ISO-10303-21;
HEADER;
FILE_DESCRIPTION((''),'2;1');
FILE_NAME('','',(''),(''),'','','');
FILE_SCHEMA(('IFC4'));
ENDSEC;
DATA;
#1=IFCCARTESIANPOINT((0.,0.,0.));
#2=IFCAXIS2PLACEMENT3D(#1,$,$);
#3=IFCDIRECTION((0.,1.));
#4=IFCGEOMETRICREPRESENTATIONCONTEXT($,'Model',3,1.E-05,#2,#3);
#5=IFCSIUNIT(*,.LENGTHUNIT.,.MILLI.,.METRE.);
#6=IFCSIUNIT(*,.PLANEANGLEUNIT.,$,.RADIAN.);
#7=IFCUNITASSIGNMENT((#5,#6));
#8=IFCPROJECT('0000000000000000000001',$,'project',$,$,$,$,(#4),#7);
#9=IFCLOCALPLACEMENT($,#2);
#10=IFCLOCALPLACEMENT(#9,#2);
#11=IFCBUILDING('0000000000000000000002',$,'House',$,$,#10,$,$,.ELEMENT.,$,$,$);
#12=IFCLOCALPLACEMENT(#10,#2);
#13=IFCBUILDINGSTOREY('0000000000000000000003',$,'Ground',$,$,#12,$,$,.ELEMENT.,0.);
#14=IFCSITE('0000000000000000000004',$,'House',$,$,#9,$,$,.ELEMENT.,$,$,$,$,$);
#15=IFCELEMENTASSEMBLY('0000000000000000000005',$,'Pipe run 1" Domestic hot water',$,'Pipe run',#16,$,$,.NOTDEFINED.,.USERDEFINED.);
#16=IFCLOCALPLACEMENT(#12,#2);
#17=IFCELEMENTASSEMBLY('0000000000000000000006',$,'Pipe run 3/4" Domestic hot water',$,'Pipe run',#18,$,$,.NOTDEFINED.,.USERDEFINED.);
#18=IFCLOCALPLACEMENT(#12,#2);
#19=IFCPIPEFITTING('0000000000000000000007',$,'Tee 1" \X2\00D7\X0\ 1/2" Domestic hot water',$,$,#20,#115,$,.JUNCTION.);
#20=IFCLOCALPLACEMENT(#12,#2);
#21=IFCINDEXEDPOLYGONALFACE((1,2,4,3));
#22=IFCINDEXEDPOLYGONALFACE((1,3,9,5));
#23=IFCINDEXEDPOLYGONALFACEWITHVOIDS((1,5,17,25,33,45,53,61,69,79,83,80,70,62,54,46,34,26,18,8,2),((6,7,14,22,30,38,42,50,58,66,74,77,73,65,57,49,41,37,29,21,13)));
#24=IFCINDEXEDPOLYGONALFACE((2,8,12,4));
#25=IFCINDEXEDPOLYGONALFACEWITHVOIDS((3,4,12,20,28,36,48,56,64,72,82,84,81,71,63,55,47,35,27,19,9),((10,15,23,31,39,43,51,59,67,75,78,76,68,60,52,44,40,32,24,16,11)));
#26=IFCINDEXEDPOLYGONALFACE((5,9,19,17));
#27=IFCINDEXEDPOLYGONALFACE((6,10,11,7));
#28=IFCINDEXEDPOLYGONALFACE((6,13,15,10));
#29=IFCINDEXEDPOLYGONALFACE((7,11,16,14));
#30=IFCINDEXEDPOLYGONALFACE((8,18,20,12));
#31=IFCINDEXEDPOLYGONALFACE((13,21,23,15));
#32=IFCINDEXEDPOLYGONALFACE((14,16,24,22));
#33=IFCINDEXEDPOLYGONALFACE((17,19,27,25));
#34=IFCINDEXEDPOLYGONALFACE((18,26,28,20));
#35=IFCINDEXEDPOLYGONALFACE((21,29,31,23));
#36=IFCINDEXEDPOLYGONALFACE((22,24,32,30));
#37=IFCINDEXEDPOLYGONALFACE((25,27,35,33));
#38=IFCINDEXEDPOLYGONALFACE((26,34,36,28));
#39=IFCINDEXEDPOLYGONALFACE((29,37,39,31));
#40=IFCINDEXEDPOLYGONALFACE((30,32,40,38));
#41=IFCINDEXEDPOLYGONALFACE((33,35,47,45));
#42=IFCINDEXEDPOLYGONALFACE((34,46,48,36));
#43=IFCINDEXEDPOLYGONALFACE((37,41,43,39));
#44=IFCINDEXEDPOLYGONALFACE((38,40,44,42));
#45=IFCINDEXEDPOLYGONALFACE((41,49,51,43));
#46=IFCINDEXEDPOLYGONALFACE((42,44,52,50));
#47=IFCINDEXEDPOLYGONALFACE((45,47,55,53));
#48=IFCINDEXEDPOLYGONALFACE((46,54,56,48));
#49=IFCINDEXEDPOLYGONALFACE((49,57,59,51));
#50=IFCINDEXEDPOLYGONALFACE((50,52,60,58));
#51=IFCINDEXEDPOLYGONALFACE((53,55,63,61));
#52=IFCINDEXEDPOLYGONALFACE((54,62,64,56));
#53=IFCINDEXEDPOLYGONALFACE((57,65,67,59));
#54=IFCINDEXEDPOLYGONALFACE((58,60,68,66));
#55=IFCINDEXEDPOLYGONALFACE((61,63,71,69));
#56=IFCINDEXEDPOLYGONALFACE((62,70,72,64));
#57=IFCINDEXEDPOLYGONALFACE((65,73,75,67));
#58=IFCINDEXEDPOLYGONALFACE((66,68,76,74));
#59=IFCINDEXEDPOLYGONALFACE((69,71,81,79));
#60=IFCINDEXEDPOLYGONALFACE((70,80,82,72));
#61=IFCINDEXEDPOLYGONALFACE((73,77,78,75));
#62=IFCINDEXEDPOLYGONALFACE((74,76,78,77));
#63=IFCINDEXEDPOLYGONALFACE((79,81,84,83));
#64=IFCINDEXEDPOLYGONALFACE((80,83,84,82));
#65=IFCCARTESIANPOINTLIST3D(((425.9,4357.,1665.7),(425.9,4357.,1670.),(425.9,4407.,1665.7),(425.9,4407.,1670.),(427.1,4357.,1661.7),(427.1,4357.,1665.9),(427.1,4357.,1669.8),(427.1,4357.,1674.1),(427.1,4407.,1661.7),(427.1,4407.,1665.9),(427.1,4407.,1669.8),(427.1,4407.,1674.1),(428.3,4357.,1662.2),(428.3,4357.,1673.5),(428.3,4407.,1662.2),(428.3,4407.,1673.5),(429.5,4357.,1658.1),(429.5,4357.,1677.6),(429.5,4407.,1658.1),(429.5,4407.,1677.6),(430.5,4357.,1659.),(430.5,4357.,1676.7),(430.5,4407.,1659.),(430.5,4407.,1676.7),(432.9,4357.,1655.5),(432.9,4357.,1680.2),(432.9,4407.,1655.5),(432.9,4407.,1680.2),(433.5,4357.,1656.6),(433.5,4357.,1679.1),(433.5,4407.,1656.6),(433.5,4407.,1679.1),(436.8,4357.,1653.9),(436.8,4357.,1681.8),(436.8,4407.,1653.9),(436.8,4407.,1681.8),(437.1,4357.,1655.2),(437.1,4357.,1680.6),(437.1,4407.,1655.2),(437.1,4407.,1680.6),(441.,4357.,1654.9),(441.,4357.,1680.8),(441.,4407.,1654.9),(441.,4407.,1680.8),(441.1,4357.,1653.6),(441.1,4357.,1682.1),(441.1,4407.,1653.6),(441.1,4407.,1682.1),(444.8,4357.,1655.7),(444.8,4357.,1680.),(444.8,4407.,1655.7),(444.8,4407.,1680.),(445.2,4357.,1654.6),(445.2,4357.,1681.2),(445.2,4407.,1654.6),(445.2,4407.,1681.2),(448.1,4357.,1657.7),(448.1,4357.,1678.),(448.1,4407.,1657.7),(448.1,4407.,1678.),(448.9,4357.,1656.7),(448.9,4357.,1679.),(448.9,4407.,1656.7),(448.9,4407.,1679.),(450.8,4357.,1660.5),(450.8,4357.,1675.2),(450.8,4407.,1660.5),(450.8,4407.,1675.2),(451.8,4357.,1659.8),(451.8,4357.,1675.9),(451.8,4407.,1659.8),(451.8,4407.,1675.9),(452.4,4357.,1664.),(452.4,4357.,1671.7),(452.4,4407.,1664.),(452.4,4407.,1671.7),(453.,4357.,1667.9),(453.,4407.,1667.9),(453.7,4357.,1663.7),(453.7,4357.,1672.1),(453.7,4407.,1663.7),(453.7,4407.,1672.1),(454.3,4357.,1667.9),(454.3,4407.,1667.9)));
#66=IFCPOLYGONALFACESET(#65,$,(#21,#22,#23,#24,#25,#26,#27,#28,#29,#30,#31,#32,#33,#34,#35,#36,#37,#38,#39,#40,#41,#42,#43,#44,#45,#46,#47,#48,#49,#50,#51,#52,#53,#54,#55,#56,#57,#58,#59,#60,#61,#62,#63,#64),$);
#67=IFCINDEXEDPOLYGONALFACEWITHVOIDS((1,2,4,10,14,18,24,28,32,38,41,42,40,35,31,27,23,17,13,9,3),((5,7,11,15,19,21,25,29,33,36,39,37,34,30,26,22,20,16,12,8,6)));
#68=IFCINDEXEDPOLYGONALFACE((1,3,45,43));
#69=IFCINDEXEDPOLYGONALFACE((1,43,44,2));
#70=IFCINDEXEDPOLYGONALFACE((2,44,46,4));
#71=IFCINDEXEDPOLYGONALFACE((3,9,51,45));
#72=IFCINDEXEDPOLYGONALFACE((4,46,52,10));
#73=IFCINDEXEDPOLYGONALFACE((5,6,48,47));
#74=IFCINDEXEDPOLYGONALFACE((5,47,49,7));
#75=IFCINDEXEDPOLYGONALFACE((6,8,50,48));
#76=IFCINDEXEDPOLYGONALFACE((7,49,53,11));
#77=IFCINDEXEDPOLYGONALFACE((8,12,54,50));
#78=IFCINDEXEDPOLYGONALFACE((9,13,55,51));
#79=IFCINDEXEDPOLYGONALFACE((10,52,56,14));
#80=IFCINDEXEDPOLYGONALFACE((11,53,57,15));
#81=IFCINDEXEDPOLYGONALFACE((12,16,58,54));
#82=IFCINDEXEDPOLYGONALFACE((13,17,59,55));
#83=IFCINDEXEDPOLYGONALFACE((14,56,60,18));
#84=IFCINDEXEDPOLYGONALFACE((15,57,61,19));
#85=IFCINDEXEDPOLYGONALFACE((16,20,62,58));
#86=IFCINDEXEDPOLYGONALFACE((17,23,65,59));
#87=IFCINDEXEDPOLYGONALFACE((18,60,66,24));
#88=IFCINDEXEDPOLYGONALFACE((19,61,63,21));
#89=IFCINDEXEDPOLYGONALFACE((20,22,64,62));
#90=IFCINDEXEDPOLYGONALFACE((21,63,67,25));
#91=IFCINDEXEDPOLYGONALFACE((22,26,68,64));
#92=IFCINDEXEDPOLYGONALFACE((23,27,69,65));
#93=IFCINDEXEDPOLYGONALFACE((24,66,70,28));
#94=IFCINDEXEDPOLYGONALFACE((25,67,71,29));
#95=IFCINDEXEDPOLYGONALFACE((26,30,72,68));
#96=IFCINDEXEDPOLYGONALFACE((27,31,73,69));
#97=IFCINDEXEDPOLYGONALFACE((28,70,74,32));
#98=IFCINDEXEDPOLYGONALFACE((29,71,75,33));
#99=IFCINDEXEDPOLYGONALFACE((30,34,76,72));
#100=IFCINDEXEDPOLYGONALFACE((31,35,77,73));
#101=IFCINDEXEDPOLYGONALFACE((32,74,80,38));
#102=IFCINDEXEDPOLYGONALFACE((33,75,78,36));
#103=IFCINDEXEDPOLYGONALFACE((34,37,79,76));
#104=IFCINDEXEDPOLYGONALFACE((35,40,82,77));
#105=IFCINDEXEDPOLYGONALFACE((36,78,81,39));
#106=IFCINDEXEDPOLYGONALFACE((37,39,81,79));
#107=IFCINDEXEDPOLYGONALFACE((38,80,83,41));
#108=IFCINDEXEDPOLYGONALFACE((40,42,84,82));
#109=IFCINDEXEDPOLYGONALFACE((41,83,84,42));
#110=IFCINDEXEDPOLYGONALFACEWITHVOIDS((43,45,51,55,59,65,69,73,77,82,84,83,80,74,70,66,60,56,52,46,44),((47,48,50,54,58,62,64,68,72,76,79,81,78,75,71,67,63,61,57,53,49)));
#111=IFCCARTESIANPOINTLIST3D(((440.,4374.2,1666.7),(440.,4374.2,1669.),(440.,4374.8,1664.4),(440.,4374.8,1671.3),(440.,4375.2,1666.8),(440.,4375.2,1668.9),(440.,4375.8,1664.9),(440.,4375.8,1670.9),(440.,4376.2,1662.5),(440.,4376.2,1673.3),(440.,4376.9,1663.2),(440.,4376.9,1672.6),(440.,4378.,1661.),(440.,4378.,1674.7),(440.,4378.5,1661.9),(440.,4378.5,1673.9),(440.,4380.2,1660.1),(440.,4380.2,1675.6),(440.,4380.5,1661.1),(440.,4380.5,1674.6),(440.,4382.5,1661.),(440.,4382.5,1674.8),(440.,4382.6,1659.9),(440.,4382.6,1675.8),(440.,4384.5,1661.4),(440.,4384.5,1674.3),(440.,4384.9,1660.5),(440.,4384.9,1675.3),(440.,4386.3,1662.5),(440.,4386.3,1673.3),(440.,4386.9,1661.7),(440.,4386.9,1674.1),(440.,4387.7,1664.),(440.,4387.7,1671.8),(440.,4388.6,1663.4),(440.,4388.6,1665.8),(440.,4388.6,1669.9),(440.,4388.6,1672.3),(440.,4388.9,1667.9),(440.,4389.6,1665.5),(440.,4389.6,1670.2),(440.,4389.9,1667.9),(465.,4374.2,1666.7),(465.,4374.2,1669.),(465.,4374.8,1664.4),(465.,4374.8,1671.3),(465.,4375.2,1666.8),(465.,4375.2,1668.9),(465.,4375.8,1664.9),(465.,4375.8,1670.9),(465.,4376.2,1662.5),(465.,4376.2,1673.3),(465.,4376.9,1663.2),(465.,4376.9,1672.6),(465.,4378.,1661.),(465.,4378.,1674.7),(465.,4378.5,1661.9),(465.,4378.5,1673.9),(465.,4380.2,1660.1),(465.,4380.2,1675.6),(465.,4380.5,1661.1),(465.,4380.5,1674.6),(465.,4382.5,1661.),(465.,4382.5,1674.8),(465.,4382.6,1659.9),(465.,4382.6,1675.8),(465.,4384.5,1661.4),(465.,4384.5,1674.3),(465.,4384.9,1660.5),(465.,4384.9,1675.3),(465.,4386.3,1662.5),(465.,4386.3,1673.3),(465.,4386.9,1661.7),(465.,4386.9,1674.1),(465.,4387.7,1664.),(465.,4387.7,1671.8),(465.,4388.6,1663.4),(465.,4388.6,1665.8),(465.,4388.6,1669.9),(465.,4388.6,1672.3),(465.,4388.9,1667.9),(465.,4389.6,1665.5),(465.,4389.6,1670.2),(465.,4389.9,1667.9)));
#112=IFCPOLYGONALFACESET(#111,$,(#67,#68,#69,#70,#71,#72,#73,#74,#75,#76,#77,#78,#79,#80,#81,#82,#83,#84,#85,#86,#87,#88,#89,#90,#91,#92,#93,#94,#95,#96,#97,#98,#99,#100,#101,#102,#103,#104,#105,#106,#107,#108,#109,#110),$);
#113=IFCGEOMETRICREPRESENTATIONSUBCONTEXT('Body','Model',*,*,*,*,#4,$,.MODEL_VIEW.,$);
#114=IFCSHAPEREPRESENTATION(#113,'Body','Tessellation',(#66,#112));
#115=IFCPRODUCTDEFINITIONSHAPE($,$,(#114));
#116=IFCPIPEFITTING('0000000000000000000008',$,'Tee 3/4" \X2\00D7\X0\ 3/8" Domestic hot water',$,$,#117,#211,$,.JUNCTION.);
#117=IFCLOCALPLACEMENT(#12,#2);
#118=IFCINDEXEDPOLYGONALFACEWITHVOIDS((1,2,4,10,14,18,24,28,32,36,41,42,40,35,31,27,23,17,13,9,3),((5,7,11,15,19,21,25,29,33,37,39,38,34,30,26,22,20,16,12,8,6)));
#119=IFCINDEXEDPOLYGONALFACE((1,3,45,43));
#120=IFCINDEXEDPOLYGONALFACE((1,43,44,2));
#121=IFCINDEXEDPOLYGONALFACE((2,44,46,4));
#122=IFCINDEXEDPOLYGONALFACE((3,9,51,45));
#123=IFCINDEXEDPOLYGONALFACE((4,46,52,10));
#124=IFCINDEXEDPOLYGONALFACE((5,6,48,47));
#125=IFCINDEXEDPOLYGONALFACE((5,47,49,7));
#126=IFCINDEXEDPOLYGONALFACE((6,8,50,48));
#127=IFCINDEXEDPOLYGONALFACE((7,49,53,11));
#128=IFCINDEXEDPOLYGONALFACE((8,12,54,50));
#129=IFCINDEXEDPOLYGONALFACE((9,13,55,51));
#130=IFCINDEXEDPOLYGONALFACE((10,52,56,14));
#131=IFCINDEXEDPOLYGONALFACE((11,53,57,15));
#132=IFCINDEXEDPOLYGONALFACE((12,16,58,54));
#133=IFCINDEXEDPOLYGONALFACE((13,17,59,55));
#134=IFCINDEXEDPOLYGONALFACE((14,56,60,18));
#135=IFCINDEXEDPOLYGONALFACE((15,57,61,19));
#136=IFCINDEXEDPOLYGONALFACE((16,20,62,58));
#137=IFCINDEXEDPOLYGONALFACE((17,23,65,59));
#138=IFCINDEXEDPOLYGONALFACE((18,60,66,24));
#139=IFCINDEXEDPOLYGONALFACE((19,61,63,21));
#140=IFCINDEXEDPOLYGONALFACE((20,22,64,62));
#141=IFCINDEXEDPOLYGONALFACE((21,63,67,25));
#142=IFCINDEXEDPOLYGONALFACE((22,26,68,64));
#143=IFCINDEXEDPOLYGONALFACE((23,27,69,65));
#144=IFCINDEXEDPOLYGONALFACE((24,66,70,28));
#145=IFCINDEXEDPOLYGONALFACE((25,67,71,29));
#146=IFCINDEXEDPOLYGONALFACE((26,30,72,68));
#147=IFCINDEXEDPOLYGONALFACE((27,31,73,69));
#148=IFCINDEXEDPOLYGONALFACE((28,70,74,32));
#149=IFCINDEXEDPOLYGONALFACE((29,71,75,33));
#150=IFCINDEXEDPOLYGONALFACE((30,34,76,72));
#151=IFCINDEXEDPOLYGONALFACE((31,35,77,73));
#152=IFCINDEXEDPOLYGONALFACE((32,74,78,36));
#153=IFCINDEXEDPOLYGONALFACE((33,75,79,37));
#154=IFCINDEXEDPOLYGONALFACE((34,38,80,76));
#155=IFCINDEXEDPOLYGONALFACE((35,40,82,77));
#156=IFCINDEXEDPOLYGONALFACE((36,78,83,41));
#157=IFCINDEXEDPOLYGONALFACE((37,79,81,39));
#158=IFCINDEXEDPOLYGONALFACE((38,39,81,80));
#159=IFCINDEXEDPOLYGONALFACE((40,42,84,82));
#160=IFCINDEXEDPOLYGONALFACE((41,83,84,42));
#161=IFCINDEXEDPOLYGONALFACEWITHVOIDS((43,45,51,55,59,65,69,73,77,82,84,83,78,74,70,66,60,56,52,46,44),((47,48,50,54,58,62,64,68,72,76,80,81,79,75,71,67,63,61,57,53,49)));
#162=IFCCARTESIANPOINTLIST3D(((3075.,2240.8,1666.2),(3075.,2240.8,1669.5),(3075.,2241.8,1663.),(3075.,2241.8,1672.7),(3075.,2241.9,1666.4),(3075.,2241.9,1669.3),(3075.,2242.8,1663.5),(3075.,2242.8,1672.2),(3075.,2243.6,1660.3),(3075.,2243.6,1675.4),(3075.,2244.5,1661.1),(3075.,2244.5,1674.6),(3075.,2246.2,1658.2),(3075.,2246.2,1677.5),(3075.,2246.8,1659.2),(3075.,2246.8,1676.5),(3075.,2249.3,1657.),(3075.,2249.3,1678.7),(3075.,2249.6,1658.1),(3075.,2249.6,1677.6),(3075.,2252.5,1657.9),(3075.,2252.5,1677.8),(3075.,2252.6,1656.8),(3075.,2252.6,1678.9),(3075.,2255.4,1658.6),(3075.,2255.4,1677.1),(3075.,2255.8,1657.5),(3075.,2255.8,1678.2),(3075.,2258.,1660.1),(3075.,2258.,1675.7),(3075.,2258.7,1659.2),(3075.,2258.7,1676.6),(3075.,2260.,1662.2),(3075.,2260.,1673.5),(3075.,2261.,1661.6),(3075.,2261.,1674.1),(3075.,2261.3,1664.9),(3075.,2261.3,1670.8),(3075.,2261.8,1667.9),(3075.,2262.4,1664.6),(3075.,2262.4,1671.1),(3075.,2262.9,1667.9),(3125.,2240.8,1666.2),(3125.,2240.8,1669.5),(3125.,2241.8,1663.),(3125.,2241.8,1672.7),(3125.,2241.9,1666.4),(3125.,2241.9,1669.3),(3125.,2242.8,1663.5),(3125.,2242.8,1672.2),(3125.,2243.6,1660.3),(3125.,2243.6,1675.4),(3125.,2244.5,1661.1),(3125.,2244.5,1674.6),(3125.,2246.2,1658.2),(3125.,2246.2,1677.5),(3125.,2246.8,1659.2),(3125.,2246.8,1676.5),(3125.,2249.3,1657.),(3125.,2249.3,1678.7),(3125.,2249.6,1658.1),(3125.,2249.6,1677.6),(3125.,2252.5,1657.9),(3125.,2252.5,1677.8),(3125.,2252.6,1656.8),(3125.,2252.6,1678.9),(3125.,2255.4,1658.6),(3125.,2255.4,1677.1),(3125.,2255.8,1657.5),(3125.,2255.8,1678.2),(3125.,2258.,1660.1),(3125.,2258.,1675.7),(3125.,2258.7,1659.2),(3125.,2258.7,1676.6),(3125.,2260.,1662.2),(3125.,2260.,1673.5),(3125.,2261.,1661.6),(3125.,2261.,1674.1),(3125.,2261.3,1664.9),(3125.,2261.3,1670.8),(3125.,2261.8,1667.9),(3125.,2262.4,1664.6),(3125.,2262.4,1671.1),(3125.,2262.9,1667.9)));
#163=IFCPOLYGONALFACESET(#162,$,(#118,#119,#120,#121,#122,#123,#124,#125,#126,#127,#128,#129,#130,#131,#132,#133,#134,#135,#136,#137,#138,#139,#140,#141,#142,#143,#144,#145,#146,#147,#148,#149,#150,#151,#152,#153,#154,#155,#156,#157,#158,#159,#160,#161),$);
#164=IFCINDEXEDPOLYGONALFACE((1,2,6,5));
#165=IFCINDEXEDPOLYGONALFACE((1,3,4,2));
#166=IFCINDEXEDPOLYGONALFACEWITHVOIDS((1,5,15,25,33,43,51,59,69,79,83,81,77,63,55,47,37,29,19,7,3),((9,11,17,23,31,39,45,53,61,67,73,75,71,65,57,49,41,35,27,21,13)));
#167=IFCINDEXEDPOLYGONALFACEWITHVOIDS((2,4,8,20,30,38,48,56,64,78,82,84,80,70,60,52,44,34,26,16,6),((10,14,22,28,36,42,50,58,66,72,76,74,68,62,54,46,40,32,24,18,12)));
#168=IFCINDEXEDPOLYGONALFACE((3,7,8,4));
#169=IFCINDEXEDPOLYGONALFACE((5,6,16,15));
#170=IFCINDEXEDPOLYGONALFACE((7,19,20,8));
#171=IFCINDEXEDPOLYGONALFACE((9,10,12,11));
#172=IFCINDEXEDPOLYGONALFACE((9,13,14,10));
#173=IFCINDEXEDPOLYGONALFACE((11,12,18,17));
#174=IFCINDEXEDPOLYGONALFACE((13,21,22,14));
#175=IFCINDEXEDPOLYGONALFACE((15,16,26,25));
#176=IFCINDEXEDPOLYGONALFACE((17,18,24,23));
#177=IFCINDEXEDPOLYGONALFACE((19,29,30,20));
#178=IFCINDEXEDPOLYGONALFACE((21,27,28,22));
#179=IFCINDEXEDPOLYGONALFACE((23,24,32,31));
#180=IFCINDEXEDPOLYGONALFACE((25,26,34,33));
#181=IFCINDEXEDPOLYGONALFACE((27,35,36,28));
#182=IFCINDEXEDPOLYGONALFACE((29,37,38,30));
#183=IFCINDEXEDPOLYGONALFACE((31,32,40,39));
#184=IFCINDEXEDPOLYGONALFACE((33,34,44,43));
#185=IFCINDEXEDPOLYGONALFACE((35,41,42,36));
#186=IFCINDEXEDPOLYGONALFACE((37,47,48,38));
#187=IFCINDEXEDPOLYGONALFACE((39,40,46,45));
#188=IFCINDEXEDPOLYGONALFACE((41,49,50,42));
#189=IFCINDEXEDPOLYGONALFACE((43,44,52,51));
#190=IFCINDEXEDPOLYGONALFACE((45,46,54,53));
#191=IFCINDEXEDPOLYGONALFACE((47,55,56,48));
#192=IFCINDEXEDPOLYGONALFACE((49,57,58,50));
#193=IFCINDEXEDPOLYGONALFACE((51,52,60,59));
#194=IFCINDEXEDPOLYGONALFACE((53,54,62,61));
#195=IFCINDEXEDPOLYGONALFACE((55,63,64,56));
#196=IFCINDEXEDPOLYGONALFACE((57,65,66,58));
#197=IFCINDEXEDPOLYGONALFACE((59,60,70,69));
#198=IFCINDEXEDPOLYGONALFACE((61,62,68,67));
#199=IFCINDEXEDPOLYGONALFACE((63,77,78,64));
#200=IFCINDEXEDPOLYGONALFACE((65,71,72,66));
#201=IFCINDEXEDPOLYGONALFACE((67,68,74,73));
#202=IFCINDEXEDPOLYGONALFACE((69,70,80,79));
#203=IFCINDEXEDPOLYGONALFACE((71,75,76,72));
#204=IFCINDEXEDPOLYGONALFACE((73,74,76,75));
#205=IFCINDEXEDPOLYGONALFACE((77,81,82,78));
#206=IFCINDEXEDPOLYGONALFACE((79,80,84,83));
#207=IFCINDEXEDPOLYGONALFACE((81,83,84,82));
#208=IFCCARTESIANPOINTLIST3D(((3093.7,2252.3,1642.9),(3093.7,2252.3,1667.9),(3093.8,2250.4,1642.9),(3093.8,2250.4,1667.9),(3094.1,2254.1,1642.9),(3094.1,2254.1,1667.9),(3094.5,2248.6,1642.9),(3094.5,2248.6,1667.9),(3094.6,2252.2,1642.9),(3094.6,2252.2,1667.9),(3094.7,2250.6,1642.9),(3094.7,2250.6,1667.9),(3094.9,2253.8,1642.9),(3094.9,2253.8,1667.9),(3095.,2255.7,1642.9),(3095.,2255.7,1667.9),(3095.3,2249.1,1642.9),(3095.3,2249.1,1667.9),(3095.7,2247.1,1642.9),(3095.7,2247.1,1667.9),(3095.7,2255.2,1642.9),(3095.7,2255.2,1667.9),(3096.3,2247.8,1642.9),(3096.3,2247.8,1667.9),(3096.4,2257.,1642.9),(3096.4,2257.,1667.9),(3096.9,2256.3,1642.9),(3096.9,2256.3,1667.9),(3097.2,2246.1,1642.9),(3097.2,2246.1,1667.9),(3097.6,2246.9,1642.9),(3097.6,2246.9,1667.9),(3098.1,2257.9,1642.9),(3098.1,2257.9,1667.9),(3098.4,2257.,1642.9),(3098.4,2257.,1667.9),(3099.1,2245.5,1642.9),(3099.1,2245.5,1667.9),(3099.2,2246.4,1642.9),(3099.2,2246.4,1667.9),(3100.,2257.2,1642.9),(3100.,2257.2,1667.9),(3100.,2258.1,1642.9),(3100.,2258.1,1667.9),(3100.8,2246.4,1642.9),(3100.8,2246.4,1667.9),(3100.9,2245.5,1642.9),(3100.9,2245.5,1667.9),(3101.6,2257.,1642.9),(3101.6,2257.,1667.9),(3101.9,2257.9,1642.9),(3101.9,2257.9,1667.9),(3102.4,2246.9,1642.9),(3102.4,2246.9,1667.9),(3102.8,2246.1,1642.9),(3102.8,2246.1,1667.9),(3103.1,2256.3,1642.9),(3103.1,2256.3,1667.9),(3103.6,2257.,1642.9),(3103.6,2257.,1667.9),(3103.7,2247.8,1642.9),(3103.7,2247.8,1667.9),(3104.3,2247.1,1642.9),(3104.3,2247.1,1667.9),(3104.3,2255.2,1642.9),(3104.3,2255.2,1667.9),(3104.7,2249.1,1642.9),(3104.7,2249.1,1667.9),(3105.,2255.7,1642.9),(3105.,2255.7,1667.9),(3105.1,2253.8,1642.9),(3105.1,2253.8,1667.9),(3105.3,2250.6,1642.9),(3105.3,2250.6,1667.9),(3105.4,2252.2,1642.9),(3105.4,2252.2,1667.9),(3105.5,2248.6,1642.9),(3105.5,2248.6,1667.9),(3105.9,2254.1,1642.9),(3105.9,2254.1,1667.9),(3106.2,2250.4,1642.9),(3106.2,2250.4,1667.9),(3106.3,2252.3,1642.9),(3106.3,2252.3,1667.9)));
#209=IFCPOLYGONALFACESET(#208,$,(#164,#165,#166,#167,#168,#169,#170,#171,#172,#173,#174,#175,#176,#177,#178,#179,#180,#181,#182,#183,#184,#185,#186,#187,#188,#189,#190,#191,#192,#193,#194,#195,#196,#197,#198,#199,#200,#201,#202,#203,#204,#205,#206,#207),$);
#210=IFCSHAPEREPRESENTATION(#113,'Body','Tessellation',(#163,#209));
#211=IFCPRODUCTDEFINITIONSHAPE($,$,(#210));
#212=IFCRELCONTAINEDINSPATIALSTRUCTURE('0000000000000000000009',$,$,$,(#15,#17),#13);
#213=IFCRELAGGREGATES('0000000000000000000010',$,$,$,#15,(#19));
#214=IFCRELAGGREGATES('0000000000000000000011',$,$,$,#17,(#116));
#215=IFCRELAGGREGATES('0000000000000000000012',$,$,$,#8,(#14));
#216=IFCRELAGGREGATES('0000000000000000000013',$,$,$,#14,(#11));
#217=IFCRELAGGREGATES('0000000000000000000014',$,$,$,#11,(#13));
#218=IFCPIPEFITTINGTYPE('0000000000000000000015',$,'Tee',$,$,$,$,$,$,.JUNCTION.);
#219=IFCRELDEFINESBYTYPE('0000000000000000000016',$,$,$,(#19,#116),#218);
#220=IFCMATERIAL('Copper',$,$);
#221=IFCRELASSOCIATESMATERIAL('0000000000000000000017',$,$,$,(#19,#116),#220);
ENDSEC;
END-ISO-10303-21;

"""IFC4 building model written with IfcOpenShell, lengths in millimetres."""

from ifc_helpers import new_model, si_unit, direction, frame, origin, origin_with_axes, origin_2d, place, context, subcontext, project, spatial, hollow_circle, extrude, material, type_object, element, aggregate, save


model = new_model("IFC4")

# Units and contexts
model_context = context("Model", 3, precision=1e-05, world=origin(), true_north=direction((0.0, 1.0)))
body_context = subcontext(model_context, "Body", "Model", "MODEL_VIEW")
ifc_project = project(units=[si_unit("LENGTHUNIT", "METRE", prefix="MILLI"), si_unit("PLANEANGLEUNIT", "RADIAN")], contexts=[model_context])

# Site, building, storey
site_placement = place(None, origin())
site = spatial("IfcSite", under=ifc_project, at=site_placement, Name="House", CompositionType="ELEMENT")
building_placement = place(site_placement, origin())
building = spatial("IfcBuilding", under=site, at=building_placement, Name="House", CompositionType="ELEMENT")
storey_placement = place(building_placement, origin())
storey = spatial("IfcBuildingStorey", under=building, at=storey_placement, Name="Ground", CompositionType="ELEMENT", Elevation=0.0)

# Element assemblies
assembly_1_placement = place(storey_placement, origin_with_axes())
assembly_1 = element("IfcElementAssembly", 1, at=assembly_1_placement, inside=storey, Name="Pipe run 1\" Domestic hot water", ObjectType="Pipe run", AssemblyPlace="NOTDEFINED", PredefinedType="USERDEFINED")
ifc_material = material(Name="Copper")
assembly_2_placement = place(storey_placement, origin_with_axes())
assembly_2 = element("IfcElementAssembly", 2, at=assembly_2_placement, inside=storey, Name="Pipe run 3/4\" Domestic hot water", ObjectType="Pipe run", AssemblyPlace="NOTDEFINED", PredefinedType="USERDEFINED")

# Pipe fittings
pipe_fitting_type_1 = type_object("IfcPipeFittingType", Name="Tee", PredefinedType="JUNCTION")
pipe_fitting_1_placement = place(storey_placement, origin_with_axes())
pipe_fitting_1 = element("IfcPipeFitting", 3, at=pipe_fitting_1_placement, type_object=pipe_fitting_type_1, material=ifc_material, Name="Tee 1\" × 1/2\" Domestic hot water", PredefinedType="JUNCTION", context=body_context, shape_type="SweptSolid", body=[
    extrude(hollow_circle(Radius=14.3, WallThickness=1.3, at=origin_2d()), frame((440.0, 4407.0, 1667.9), z_axis=(0.0, -1.0, 0.0), x_axis=(1.0, 0.0, 0.0)), (0.0, 0.0, 1.0), 50.0),
    extrude(hollow_circle(Radius=7.9, WallThickness=1.0, at=origin_2d()), frame((440.0, 4382.0, 1667.9), z_axis=(1.0, 0.0, 0.0), x_axis=(0.0, 1.0, 0.0)), (0.0, 0.0, 1.0), 25.0),
])
aggregate(assembly_1, [pipe_fitting_1])
pipe_fitting_2_placement = place(storey_placement, origin_with_axes())
pipe_fitting_2 = element("IfcPipeFitting", 4, at=pipe_fitting_2_placement, type_object=pipe_fitting_type_1, material=ifc_material, Name="Tee 3/4\" × 3/8\" Domestic hot water", PredefinedType="JUNCTION", context=body_context, shape_type="SweptSolid", body=[
    extrude(hollow_circle(Radius=11.1, WallThickness=1.1, at=origin_2d()), frame((3075.0, 2251.8, 1667.9), z_axis=(1.0, 0.0, 0.0), x_axis=(0.0, 1.0, 0.0)), (0.0, 0.0, 1.0), 50.0),
    extrude(hollow_circle(Radius=6.3, WallThickness=0.9, at=origin_2d()), frame((3100.0, 2251.8, 1667.9), z_axis=(0.0, 0.0, -1.0), x_axis=(0.0, 1.0, 0.0)), (0.0, 0.0, 1.0), 25.0),
])
aggregate(assembly_2, [pipe_fitting_2])

save(model, "model.ifc")
